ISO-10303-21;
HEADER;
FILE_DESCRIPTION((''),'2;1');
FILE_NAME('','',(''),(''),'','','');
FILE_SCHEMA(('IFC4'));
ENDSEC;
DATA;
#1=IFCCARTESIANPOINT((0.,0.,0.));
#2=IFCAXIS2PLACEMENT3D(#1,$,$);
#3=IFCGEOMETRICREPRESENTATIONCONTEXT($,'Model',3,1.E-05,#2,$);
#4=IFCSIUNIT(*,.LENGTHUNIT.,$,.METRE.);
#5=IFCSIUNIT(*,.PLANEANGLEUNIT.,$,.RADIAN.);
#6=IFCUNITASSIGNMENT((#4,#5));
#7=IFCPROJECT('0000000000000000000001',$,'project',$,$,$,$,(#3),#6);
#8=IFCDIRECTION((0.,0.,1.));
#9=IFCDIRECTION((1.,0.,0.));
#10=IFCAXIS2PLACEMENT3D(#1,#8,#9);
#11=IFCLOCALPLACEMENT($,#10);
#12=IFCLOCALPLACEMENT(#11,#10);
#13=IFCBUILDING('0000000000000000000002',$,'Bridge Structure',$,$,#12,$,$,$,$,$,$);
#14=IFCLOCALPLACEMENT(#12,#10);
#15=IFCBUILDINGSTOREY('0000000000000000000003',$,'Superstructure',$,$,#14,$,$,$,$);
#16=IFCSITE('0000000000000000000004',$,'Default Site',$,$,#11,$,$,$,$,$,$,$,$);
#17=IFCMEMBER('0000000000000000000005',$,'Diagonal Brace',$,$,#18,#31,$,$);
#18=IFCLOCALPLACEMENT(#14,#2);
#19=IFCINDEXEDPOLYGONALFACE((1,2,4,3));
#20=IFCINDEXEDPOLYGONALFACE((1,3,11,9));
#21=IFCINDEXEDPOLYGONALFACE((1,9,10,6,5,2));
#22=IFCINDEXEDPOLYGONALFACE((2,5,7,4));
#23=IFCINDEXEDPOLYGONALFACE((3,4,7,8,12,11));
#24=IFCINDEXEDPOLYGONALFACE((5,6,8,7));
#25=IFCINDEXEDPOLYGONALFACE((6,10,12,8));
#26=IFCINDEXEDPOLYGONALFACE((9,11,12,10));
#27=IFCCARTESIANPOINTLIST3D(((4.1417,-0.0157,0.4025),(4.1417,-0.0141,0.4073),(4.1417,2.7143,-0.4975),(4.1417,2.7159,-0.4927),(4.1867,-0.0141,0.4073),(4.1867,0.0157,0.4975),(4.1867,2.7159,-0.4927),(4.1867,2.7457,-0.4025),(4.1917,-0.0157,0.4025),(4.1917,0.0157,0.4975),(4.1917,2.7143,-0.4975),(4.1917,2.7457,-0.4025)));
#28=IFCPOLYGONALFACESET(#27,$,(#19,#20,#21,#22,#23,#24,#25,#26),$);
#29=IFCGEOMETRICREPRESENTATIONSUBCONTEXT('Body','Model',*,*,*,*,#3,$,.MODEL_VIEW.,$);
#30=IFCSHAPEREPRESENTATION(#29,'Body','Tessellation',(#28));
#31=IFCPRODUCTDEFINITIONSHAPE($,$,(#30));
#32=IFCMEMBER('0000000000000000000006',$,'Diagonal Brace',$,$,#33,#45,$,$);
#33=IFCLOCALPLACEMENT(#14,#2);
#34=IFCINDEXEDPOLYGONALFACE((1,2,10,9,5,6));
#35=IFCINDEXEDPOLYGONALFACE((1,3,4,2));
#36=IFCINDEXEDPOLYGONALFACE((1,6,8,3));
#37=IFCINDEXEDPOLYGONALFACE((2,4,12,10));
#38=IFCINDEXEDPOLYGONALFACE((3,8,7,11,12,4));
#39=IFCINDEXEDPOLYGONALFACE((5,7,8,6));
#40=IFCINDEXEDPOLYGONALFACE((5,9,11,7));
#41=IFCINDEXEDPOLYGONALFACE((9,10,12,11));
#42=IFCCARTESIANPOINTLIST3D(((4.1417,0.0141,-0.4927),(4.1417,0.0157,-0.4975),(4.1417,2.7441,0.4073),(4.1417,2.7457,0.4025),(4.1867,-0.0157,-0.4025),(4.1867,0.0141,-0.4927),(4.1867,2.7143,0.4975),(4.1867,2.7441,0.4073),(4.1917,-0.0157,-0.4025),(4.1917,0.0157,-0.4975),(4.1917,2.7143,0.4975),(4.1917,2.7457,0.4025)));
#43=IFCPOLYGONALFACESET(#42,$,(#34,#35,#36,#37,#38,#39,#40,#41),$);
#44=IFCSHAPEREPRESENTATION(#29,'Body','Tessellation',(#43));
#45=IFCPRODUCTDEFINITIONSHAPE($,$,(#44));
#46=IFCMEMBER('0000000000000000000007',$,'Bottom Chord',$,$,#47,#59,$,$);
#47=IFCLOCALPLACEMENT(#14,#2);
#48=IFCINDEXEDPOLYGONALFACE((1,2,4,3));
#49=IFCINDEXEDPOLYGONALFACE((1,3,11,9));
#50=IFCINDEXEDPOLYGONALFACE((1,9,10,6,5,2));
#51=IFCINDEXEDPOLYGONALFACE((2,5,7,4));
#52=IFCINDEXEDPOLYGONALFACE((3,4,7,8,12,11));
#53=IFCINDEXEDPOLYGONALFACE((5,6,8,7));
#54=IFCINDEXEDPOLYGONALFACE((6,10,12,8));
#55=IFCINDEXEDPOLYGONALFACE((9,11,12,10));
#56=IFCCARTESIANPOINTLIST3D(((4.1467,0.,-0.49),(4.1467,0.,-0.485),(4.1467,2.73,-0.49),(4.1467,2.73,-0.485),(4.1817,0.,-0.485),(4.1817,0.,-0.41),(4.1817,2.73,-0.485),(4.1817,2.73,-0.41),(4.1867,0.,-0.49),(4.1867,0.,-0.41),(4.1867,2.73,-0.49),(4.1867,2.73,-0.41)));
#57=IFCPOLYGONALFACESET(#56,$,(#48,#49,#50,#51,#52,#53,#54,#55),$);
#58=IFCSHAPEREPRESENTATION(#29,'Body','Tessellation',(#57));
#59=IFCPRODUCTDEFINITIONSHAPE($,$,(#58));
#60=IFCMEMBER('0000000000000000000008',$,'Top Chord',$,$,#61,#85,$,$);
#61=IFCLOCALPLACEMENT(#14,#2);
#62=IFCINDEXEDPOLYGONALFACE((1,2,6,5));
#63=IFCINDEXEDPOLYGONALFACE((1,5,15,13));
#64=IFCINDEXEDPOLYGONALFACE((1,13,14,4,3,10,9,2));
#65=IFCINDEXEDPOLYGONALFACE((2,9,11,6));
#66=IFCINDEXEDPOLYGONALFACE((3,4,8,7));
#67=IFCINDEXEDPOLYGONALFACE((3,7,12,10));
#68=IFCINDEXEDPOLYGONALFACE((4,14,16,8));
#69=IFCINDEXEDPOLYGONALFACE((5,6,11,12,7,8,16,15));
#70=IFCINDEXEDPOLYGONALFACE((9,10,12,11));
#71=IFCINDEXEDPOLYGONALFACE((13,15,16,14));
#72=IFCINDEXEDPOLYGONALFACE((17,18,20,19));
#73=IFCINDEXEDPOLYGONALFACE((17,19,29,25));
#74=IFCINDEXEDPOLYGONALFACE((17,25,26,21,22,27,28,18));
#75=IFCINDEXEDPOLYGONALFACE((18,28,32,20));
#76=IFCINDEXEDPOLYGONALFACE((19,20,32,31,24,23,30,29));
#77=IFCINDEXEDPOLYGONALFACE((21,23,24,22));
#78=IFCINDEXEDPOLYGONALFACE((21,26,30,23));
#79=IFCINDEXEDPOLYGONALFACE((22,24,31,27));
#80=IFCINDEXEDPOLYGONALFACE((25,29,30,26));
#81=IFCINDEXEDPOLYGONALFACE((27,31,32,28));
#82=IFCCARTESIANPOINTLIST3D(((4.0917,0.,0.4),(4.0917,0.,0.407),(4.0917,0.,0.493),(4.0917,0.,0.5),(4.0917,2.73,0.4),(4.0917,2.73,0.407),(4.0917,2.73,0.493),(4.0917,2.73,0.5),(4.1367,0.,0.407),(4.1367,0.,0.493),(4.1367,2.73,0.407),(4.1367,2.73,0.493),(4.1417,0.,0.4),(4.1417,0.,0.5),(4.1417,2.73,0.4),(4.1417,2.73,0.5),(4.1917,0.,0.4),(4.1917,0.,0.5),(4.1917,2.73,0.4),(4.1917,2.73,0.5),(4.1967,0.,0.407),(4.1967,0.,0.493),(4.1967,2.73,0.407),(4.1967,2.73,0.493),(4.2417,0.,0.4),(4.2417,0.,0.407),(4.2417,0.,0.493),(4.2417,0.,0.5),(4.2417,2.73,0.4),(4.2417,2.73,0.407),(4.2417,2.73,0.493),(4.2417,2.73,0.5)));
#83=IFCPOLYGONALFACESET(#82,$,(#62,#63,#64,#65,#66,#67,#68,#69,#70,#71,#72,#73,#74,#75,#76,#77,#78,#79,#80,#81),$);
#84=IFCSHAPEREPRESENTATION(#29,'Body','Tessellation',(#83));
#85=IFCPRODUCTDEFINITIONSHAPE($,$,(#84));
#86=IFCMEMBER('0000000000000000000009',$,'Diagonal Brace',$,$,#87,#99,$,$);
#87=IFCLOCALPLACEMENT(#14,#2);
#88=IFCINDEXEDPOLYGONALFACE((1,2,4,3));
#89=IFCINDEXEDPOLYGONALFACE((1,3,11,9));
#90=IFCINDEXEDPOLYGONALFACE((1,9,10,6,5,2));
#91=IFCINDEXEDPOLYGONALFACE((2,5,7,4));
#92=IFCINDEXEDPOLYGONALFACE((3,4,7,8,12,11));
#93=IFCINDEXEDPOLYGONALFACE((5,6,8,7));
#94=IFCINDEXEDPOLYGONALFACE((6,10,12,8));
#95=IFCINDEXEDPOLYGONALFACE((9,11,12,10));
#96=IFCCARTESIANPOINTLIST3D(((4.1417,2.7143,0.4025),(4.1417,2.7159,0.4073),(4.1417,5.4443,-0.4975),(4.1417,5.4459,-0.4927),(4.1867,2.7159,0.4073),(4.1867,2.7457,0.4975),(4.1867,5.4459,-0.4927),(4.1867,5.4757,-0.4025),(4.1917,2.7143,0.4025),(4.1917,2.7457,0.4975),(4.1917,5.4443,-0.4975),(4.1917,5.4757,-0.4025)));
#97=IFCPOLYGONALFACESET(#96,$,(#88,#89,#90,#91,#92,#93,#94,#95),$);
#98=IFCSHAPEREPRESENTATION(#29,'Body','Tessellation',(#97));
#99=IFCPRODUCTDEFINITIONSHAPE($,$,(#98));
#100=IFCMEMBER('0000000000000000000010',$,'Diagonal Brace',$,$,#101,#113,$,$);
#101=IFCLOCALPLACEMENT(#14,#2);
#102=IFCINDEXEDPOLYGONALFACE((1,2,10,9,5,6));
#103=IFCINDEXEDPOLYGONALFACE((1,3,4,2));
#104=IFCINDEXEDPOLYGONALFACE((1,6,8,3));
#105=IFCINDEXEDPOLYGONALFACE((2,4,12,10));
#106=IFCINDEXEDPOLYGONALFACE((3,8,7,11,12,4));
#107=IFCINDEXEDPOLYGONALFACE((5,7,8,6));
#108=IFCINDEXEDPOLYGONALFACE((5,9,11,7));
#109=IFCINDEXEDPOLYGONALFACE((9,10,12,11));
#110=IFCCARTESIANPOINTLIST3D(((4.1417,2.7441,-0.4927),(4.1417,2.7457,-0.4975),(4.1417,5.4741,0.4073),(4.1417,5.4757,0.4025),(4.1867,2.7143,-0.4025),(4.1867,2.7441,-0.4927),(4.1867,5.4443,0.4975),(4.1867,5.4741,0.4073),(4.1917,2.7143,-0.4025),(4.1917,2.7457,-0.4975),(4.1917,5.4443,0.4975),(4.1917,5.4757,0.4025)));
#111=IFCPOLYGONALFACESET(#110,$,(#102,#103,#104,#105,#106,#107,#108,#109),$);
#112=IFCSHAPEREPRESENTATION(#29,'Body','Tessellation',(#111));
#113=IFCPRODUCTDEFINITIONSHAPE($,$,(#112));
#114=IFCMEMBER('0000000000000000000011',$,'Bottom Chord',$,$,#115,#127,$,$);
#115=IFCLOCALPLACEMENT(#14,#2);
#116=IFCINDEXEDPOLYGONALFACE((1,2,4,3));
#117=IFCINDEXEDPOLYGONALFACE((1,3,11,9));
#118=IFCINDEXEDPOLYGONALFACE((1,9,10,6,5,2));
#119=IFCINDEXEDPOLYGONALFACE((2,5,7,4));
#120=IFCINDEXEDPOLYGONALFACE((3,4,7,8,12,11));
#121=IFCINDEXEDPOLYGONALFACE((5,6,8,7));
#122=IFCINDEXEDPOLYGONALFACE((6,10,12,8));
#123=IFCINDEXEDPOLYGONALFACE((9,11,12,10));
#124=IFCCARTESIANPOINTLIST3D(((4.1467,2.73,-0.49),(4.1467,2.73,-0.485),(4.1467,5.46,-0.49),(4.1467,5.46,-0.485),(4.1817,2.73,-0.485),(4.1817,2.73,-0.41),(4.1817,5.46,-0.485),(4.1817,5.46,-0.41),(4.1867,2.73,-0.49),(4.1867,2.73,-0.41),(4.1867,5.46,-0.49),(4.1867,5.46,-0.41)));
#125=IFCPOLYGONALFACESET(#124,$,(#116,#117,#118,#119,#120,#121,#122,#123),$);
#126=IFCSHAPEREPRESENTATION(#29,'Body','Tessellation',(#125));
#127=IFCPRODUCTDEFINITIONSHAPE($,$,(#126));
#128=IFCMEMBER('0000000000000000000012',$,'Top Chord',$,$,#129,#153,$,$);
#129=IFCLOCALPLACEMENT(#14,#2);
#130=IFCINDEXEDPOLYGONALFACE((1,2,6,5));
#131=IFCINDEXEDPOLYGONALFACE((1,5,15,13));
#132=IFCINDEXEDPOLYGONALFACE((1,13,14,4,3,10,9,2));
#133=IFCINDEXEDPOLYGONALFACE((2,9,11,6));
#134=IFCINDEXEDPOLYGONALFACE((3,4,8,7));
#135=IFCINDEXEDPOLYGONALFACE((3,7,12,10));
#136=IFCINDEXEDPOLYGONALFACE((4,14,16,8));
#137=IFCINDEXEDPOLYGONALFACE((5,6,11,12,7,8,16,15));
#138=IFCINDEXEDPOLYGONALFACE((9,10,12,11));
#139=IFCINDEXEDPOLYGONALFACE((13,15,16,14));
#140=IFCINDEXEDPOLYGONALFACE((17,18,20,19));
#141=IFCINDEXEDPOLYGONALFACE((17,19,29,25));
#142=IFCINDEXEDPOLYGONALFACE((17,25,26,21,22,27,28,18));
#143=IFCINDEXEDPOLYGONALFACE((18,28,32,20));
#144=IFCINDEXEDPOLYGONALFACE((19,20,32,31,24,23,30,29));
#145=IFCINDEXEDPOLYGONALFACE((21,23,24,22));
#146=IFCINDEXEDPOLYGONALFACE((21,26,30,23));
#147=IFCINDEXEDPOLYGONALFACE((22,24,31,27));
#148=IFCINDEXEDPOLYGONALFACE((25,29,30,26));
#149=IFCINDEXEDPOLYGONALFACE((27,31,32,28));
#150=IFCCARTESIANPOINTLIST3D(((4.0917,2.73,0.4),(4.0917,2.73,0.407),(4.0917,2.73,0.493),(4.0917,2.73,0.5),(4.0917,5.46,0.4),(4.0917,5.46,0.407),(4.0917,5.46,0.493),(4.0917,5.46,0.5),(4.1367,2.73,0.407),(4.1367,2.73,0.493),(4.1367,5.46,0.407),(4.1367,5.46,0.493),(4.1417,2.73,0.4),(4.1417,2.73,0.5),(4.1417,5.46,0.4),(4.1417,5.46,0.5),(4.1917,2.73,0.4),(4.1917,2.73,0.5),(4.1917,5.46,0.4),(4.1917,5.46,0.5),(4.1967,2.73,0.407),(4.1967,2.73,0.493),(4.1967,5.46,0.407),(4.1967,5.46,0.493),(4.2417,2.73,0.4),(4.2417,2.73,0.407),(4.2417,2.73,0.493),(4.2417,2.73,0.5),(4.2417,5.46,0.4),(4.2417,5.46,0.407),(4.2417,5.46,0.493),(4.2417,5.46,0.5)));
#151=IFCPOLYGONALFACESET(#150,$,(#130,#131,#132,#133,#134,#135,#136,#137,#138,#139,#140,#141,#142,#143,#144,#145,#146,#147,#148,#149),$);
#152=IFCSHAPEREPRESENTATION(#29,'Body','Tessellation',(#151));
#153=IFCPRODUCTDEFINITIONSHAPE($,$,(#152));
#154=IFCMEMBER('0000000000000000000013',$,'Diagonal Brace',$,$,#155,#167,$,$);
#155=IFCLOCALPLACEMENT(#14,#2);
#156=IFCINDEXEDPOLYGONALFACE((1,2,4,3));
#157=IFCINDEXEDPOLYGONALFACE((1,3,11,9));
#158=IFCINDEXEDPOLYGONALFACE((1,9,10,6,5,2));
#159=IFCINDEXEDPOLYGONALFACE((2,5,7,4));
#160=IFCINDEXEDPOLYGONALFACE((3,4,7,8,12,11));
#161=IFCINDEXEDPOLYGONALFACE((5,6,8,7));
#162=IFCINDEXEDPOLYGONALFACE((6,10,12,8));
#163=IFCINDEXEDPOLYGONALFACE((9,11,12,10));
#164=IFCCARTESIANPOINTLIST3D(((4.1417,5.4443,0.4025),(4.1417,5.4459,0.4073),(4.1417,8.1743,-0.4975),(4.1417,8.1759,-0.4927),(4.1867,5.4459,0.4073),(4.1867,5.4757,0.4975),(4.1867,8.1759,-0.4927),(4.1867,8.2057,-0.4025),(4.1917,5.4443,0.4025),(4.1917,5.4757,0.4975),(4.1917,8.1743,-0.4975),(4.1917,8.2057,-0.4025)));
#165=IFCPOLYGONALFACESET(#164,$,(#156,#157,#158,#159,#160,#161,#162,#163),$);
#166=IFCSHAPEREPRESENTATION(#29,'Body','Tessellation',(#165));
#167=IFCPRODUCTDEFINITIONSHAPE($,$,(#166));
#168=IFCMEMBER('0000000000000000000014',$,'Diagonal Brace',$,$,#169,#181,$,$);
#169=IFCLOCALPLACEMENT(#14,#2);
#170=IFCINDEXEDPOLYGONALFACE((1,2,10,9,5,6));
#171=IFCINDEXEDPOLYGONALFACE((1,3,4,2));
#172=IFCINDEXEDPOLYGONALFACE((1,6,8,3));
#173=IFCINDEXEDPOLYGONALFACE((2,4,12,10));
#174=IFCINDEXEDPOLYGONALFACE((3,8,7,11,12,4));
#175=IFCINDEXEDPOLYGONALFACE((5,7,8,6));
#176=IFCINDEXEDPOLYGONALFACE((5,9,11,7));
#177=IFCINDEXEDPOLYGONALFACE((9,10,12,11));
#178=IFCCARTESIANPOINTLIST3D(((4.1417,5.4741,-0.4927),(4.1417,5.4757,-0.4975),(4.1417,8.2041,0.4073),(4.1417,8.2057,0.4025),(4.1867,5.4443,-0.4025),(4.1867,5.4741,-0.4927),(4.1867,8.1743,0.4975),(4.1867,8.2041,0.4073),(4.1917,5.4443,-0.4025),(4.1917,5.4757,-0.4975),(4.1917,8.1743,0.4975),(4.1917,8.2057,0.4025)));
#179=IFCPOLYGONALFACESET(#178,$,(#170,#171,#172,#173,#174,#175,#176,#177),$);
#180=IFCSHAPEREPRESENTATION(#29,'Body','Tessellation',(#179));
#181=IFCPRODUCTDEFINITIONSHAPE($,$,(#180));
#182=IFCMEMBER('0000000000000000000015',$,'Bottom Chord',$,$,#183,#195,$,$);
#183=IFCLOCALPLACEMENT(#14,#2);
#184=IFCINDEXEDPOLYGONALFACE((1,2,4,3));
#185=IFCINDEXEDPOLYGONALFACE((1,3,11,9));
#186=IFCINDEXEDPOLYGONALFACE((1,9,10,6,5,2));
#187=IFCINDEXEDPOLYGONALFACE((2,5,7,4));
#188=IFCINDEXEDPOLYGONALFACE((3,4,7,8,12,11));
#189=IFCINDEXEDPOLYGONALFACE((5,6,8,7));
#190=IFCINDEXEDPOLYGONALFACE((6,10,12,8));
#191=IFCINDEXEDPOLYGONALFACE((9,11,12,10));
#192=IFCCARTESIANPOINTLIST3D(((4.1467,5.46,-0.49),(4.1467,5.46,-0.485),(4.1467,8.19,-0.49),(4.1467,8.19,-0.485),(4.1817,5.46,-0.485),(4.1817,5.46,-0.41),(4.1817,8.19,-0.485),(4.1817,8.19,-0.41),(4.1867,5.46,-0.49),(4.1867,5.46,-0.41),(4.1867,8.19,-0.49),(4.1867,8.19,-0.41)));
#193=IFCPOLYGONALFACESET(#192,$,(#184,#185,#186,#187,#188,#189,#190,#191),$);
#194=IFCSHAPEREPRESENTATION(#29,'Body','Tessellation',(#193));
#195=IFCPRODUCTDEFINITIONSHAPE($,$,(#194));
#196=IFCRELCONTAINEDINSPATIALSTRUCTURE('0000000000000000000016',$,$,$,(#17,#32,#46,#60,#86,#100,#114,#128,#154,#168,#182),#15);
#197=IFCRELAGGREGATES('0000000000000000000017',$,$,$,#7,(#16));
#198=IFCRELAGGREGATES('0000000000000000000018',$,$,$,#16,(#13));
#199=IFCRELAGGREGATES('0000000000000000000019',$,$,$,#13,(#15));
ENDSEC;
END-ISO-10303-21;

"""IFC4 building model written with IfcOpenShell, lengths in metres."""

from ifc_helpers import new_model, si_unit, frame, origin, origin_with_axes, origin_2d_with_axis, place, context, subcontext, project, spatial, polyline, l_section, outline, composite_profile, extrude, element, save


model = new_model("IFC4")

# Units and contexts
model_context = context("Model", 3, precision=1e-05, world=origin())
body_context = subcontext(model_context, "Body", "Model", "MODEL_VIEW")
ifc_project = project(units=[si_unit("LENGTHUNIT", "METRE"), si_unit("PLANEANGLEUNIT", "RADIAN")], contexts=[model_context])

# Site, building, storey
site_placement = place(None, origin_with_axes())
site = spatial("IfcSite", under=ifc_project, at=site_placement, Name="Default Site")
building_placement = place(site_placement, origin_with_axes())
building = spatial("IfcBuilding", under=site, at=building_placement, Name="Bridge Structure")
storey_placement = place(building_placement, origin_with_axes())
storey = spatial("IfcBuildingStorey", under=building, at=storey_placement, Name="Superstructure")

# Members
for number, where, z_axis, x_axis, name in (
    (1, (4.1667, 0.0, 0.45), (0.0, 0.949722, -0.313095), (-1.0, 0.0, 0.0), "Diagonal Brace"),
    (2, (4.1667, 0.0, -0.45), (0.0, 0.949722, 0.313095), (-1.0, 0.0, 0.0), "Diagonal Brace"),
):
    element("IfcMember", number, at=place(storey_placement, frame(where, z_axis=z_axis, x_axis=x_axis)), inside=storey, Name=name, context=body_context, shape_type="SweptSolid", body=[
        extrude(l_section(Depth=0.1, Width=0.05, Thickness=0.005, at=origin_2d_with_axis()), origin_with_axes(), (0.0, 0.0, 1.0), 2.8745),
    ])
member_1_placement = place(storey_placement, frame((4.1667, 0.0, -0.45), z_axis=(0.0, 1.0, 0.0), x_axis=(-1.0, 0.0, 0.0)))
element("IfcMember", 3, at=member_1_placement, inside=storey, Name="Bottom Chord", context=body_context, shape_type="SweptSolid", body=[
    extrude(l_section(Depth=0.08, Width=0.04, Thickness=0.005, at=origin_2d_with_axis()), origin_with_axes(), (0.0, 0.0, 1.0), 2.73),
])
member_2_placement = place(storey_placement, frame((4.1667, 0.0, 0.45), z_axis=(0.0, 1.0, 0.0), x_axis=(-1.0, 0.0, 0.0)))
element("IfcMember", 4, at=member_2_placement, inside=storey, Name="Top Chord", context=body_context, shape_type="SweptSolid", body=[
    extrude(composite_profile([outline(polyline([(-0.025, -0.05), (-0.025, 0.05), (-0.075, 0.05), (-0.075, 0.043), (-0.03, 0.043), (-0.03, -0.043), (-0.075, -0.043), (-0.075, -0.05), (-0.025, -0.05)])), outline(polyline([(0.025, -0.05), (0.075, -0.05), (0.075, -0.043), (0.03, -0.043), (0.03, 0.043), (0.075, 0.043), (0.075, 0.05), (0.025, 0.05), (0.025, -0.05)]))]), origin_with_axes(), (0.0, 0.0, 1.0), 2.73),
])
for number, where, z_axis, x_axis, name in (
    (5, (4.1667, 2.73, 0.45), (0.0, 0.949722, -0.313095), (-1.0, 0.0, 0.0), "Diagonal Brace"),
    (6, (4.1667, 2.73, -0.45), (0.0, 0.949722, 0.313095), (-1.0, 0.0, 0.0), "Diagonal Brace"),
):
    element("IfcMember", number, at=place(storey_placement, frame(where, z_axis=z_axis, x_axis=x_axis)), inside=storey, Name=name, context=body_context, shape_type="SweptSolid", body=[
        extrude(l_section(Depth=0.1, Width=0.05, Thickness=0.005, at=origin_2d_with_axis()), origin_with_axes(), (0.0, 0.0, 1.0), 2.8745),
    ])
member_3_placement = place(storey_placement, frame((4.1667, 2.73, -0.45), z_axis=(0.0, 1.0, 0.0), x_axis=(-1.0, 0.0, 0.0)))
element("IfcMember", 7, at=member_3_placement, inside=storey, Name="Bottom Chord", context=body_context, shape_type="SweptSolid", body=[
    extrude(l_section(Depth=0.08, Width=0.04, Thickness=0.005, at=origin_2d_with_axis()), origin_with_axes(), (0.0, 0.0, 1.0), 2.73),
])
member_4_placement = place(storey_placement, frame((4.1667, 2.73, 0.45), z_axis=(0.0, 1.0, 0.0), x_axis=(-1.0, 0.0, 0.0)))
element("IfcMember", 8, at=member_4_placement, inside=storey, Name="Top Chord", context=body_context, shape_type="SweptSolid", body=[
    extrude(composite_profile([outline(polyline([(-0.025, -0.05), (-0.025, 0.05), (-0.075, 0.05), (-0.075, 0.043), (-0.03, 0.043), (-0.03, -0.043), (-0.075, -0.043), (-0.075, -0.05), (-0.025, -0.05)])), outline(polyline([(0.025, -0.05), (0.075, -0.05), (0.075, -0.043), (0.03, -0.043), (0.03, 0.043), (0.075, 0.043), (0.075, 0.05), (0.025, 0.05), (0.025, -0.05)]))]), origin_with_axes(), (0.0, 0.0, 1.0), 2.73),
])
for number, where, z_axis, x_axis, name in (
    (9, (4.1667, 5.46, 0.45), (0.0, 0.949722, -0.313095), (-1.0, 0.0, 0.0), "Diagonal Brace"),
    (10, (4.1667, 5.46, -0.45), (0.0, 0.949722, 0.313095), (-1.0, 0.0, 0.0), "Diagonal Brace"),
):
    element("IfcMember", number, at=place(storey_placement, frame(where, z_axis=z_axis, x_axis=x_axis)), inside=storey, Name=name, context=body_context, shape_type="SweptSolid", body=[
        extrude(l_section(Depth=0.1, Width=0.05, Thickness=0.005, at=origin_2d_with_axis()), origin_with_axes(), (0.0, 0.0, 1.0), 2.8745),
    ])
member_5_placement = place(storey_placement, frame((4.1667, 5.46, -0.45), z_axis=(0.0, 1.0, 0.0), x_axis=(-1.0, 0.0, 0.0)))
element("IfcMember", 11, at=member_5_placement, inside=storey, Name="Bottom Chord", context=body_context, shape_type="SweptSolid", body=[
    extrude(l_section(Depth=0.08, Width=0.04, Thickness=0.005, at=origin_2d_with_axis()), origin_with_axes(), (0.0, 0.0, 1.0), 2.73),
])

save(model, "model.ifc")
